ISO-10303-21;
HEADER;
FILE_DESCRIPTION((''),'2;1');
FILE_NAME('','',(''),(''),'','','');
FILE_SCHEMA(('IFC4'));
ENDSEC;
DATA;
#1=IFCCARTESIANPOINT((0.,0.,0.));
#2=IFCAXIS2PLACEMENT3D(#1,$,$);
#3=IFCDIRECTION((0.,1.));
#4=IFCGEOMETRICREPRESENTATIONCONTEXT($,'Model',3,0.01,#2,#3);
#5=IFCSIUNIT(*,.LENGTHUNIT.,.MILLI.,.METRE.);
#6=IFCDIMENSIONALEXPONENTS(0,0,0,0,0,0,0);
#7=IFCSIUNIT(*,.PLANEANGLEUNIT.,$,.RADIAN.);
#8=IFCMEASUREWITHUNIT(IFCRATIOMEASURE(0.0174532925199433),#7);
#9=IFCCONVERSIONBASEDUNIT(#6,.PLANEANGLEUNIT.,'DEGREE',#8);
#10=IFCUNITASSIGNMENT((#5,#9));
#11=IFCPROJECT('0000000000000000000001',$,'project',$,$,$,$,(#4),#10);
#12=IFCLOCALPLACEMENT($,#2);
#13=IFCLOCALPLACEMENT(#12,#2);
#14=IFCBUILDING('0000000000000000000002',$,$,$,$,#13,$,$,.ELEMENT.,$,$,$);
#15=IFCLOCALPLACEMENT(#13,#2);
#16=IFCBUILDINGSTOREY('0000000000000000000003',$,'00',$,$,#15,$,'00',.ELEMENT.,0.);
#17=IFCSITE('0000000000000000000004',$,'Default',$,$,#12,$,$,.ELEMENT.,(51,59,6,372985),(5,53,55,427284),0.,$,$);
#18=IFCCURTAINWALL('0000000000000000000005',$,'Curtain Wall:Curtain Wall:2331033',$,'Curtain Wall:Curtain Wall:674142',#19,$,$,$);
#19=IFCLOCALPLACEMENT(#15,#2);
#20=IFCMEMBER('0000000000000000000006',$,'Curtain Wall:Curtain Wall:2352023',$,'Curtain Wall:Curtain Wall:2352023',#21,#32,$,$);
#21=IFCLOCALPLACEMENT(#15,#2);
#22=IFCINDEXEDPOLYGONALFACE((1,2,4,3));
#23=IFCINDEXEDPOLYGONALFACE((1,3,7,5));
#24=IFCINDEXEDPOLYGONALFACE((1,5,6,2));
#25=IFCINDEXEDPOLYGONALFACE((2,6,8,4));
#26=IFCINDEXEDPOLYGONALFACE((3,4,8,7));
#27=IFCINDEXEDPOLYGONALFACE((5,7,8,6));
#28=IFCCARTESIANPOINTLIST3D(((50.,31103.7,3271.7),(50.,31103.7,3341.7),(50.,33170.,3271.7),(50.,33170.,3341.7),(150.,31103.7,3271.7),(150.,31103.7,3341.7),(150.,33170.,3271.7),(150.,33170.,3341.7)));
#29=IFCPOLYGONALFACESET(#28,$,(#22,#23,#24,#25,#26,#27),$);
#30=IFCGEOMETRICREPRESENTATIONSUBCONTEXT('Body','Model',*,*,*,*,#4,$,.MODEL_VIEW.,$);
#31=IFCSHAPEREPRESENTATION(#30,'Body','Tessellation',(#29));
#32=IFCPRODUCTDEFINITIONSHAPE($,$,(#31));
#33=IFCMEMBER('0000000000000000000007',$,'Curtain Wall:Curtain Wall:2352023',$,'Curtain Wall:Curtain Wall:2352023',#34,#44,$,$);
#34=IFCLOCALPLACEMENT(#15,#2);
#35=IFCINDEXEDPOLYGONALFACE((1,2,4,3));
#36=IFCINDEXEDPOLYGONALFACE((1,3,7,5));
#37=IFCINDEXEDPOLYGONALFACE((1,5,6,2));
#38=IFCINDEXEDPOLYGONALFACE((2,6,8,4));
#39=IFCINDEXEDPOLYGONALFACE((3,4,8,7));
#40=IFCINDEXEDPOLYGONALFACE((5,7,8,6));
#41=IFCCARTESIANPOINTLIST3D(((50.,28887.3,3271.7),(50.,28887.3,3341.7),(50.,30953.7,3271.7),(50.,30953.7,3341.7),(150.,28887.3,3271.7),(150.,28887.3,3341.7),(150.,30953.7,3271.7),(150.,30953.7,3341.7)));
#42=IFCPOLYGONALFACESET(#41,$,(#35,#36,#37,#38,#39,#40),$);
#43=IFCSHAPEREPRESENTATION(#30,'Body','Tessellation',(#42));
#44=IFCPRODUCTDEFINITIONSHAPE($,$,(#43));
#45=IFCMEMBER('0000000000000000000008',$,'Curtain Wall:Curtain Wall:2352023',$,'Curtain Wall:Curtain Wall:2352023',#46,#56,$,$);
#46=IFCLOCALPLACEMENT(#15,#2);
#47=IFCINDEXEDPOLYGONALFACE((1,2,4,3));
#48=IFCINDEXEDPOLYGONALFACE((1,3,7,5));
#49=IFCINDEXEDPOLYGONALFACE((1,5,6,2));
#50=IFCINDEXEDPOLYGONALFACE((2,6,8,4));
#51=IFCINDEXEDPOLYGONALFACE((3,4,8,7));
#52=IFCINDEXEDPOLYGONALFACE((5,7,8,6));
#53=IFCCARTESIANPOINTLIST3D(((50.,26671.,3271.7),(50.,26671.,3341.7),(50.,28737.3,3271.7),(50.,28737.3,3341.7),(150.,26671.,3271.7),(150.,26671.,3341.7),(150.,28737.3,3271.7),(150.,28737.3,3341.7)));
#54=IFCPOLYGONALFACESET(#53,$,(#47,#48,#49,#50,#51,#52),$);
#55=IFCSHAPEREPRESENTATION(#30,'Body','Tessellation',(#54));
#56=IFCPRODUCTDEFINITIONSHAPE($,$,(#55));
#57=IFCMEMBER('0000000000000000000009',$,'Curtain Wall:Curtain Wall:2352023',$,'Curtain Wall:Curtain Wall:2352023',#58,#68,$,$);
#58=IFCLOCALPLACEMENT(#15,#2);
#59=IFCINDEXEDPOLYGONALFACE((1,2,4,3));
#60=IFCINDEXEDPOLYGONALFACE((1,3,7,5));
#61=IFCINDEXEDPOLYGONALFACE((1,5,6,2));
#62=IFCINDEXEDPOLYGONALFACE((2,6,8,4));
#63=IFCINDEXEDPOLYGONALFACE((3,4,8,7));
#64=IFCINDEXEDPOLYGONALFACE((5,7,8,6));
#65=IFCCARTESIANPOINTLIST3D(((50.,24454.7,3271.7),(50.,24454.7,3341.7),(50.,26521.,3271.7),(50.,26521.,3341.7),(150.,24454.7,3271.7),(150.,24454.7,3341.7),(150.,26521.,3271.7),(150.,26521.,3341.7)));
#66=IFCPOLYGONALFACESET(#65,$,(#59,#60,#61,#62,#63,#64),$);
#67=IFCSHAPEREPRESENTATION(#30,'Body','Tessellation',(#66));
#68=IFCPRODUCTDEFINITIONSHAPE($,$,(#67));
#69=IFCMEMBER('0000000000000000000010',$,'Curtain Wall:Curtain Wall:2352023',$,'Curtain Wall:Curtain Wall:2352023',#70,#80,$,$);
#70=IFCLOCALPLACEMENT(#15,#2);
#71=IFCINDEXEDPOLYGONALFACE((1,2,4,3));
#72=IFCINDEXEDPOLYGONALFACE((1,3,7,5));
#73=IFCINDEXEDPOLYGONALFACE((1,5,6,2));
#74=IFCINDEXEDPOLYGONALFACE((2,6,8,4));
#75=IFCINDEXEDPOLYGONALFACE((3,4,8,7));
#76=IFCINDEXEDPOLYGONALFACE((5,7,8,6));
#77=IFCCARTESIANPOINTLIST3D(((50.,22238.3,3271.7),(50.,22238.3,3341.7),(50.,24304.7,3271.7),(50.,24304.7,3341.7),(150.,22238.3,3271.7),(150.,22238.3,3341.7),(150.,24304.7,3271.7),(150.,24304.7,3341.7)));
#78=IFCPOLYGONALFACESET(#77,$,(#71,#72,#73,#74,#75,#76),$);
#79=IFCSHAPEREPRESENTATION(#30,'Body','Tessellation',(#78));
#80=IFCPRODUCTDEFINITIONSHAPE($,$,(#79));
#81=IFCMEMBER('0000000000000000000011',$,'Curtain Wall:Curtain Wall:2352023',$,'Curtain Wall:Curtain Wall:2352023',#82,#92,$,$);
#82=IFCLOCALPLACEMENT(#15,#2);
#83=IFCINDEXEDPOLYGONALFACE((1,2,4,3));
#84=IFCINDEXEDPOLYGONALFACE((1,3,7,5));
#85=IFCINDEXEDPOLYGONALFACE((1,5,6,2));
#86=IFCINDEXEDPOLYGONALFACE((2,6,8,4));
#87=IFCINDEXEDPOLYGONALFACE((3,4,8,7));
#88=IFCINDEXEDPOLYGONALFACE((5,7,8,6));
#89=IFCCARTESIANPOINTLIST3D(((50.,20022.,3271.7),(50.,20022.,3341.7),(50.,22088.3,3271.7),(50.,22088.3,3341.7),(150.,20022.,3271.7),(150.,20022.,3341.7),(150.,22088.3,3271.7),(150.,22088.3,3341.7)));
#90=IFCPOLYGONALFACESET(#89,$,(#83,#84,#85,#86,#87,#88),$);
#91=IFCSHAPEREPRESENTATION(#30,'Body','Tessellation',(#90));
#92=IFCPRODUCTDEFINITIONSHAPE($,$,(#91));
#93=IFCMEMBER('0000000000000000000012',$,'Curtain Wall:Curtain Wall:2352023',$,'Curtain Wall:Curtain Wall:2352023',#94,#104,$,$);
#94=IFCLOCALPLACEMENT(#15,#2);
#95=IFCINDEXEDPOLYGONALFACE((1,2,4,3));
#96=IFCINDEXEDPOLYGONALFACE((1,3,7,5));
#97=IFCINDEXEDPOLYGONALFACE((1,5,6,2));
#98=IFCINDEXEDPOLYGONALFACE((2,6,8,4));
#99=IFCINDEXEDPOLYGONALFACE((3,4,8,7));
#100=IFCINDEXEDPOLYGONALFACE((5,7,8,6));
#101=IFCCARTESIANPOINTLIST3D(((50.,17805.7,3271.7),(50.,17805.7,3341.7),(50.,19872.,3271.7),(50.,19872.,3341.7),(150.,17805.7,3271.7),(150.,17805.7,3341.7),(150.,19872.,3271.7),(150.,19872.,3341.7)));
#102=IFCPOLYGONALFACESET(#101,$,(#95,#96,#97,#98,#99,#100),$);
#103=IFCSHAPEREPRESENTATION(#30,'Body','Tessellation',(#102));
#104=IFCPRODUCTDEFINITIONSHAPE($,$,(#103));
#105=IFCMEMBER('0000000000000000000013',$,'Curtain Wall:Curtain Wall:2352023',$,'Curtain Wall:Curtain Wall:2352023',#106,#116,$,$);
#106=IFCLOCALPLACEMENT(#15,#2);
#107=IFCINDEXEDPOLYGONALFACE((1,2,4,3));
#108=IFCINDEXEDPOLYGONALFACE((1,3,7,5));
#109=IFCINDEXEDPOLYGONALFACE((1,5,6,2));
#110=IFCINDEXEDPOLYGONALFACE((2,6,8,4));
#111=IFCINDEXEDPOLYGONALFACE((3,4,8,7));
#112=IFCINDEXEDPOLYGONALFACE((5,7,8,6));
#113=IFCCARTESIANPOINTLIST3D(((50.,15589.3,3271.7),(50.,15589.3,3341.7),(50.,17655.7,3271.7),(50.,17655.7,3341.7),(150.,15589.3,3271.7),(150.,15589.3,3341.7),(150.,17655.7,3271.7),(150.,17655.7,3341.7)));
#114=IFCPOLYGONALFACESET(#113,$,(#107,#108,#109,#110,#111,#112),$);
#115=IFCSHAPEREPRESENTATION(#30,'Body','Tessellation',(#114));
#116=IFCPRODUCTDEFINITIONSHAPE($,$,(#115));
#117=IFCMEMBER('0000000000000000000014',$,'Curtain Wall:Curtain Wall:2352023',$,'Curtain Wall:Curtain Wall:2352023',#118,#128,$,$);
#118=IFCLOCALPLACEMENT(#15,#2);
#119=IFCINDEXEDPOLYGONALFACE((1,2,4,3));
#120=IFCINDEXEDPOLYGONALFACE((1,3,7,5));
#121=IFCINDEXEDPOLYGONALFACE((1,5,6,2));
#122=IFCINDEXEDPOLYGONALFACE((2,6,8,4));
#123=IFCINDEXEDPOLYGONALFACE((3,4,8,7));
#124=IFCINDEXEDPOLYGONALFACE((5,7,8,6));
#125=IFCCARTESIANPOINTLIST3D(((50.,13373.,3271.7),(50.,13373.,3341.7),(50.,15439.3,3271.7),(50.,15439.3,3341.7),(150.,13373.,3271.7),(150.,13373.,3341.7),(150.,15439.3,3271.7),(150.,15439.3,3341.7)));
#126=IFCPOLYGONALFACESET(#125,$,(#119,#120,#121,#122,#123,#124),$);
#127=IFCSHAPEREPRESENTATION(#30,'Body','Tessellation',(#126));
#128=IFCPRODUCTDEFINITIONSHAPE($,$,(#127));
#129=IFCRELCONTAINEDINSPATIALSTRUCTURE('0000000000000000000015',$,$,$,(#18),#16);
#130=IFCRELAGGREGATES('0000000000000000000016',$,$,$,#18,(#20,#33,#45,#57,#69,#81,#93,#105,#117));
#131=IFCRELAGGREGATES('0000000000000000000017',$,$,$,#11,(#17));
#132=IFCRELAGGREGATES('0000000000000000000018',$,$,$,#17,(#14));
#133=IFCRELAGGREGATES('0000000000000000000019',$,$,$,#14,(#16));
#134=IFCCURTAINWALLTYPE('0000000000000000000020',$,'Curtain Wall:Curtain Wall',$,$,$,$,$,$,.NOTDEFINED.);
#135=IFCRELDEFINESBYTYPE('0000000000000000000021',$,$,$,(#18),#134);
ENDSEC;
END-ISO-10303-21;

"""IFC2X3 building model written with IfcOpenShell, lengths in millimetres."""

from ifc_helpers import new_model, entity, si_unit, converted_unit, direction, frame, frame_2d, origin, place, context, subcontext, project, spatial, rectangle, extrude, type_object, element, aggregate, save


model = new_model("IFC2X3")

# Units and contexts
model_context = context("Model", 3, precision=0.01, world=origin(), true_north=direction((0.0, 1.0)))
body_context = subcontext(model_context, "Body", "Model", "MODEL_VIEW")
ifc_project = project(units=[si_unit("LENGTHUNIT", "METRE", prefix="MILLI"), converted_unit("PLANEANGLEUNIT", "DEGREE", entity("IfcRatioMeasure", 0.0174532925199433), si_unit("PLANEANGLEUNIT", "RADIAN"), dimensions=[0, 0, 0, 0, 0, 0, 0])], contexts=[model_context])

# Site, building, storey
site_placement = place(None, origin())
site = spatial("IfcSite", under=ifc_project, at=site_placement, Name="Default", CompositionType="ELEMENT", RefLatitude=(51, 59, 6, 372985), RefLongitude=(5, 53, 55, 427284), RefElevation=0.0)
building_placement = place(site_placement, origin())
building = spatial("IfcBuilding", under=site, at=building_placement, CompositionType="ELEMENT")
storey_placement = place(building_placement, origin())
storey = spatial("IfcBuildingStorey", under=building, at=storey_placement, Name="00", LongName="00", CompositionType="ELEMENT", Elevation=0.0)

# Curtain wall, members
curtain_wall_type = type_object("IfcCurtainWallType", Name="Curtain Wall:Curtain Wall", PredefinedType="NOTDEFINED")
curtain_wall_placement = place(storey_placement, origin())
curtain_wall = element("IfcCurtainWall", 1, at=curtain_wall_placement, inside=storey, type_object=curtain_wall_type, Name="Curtain Wall:Curtain Wall:2331033", ObjectType="Curtain Wall:Curtain Wall:674142")
member_1_placement = place(curtain_wall_placement, origin())
member_1 = element("IfcMember", 2, at=member_1_placement, Name="Curtain Wall:Curtain Wall:2352023", ObjectType="Curtain Wall:Curtain Wall:2352023", context=body_context, shape_type="SweptSolid", body=[
    extrude(rectangle(XDim=70.0, YDim=100.0, at=frame_2d((0.0, 0.0), x_axis=(1.0, 0.0))), frame((100.0, 31103.7, 3306.7), z_axis=(0.0, 1.0, 0.0), x_axis=(0.0, 0.0, -1.0)), (0.0, 0.0, 1.0), 2066.3),
])
member_2_placement = place(curtain_wall_placement, origin())
member_2 = element("IfcMember", 3, at=member_2_placement, Name="Curtain Wall:Curtain Wall:2352023", ObjectType="Curtain Wall:Curtain Wall:2352023", context=body_context, shape_type="SweptSolid", body=[
    extrude(rectangle(XDim=70.0, YDim=100.0, at=frame_2d((0.0, 0.0), x_axis=(1.0, 0.0))), frame((100.0, 28887.3, 3306.7), z_axis=(0.0, 1.0, 0.0), x_axis=(0.0, 0.0, -1.0)), (0.0, 0.0, 1.0), 2066.3),
])
member_3_placement = place(curtain_wall_placement, origin())
member_3 = element("IfcMember", 4, at=member_3_placement, Name="Curtain Wall:Curtain Wall:2352023", ObjectType="Curtain Wall:Curtain Wall:2352023", context=body_context, shape_type="SweptSolid", body=[
    extrude(rectangle(XDim=70.0, YDim=100.0, at=frame_2d((0.0, 0.0), x_axis=(1.0, 0.0))), frame((100.0, 26671.0, 3306.7), z_axis=(0.0, 1.0, 0.0), x_axis=(0.0, 0.0, -1.0)), (0.0, 0.0, 1.0), 2066.3),
])
member_4_placement = place(curtain_wall_placement, origin())
member_4 = element("IfcMember", 5, at=member_4_placement, Name="Curtain Wall:Curtain Wall:2352023", ObjectType="Curtain Wall:Curtain Wall:2352023", context=body_context, shape_type="SweptSolid", body=[
    extrude(rectangle(XDim=70.0, YDim=100.0, at=frame_2d((0.0, 0.0), x_axis=(1.0, 0.0))), frame((100.0, 24454.7, 3306.7), z_axis=(0.0, 1.0, 0.0), x_axis=(0.0, 0.0, -1.0)), (0.0, 0.0, 1.0), 2066.3),
])
member_5_placement = place(curtain_wall_placement, origin())
member_5 = element("IfcMember", 6, at=member_5_placement, Name="Curtain Wall:Curtain Wall:2352023", ObjectType="Curtain Wall:Curtain Wall:2352023", context=body_context, shape_type="SweptSolid", body=[
    extrude(rectangle(XDim=70.0, YDim=100.0, at=frame_2d((0.0, 0.0), x_axis=(1.0, 0.0))), frame((100.0, 22238.3, 3306.7), z_axis=(0.0, 1.0, 0.0), x_axis=(0.0, 0.0, -1.0)), (0.0, 0.0, 1.0), 2066.3),
])
member_6_placement = place(curtain_wall_placement, origin())
member_6 = element("IfcMember", 7, at=member_6_placement, Name="Curtain Wall:Curtain Wall:2352023", ObjectType="Curtain Wall:Curtain Wall:2352023", context=body_context, shape_type="SweptSolid", body=[
    extrude(rectangle(XDim=70.0, YDim=100.0, at=frame_2d((0.0, 0.0), x_axis=(1.0, 0.0))), frame((100.0, 20022.0, 3306.7), z_axis=(0.0, 1.0, 0.0), x_axis=(0.0, 0.0, -1.0)), (0.0, 0.0, 1.0), 2066.3),
])
member_7_placement = place(curtain_wall_placement, origin())
member_7 = element("IfcMember", 8, at=member_7_placement, Name="Curtain Wall:Curtain Wall:2352023", ObjectType="Curtain Wall:Curtain Wall:2352023", context=body_context, shape_type="SweptSolid", body=[
    extrude(rectangle(XDim=70.0, YDim=100.0, at=frame_2d((0.0, 0.0), x_axis=(1.0, 0.0))), frame((100.0, 17805.7, 3306.7), z_axis=(0.0, 1.0, 0.0), x_axis=(0.0, 0.0, -1.0)), (0.0, 0.0, 1.0), 2066.3),
])
member_8_placement = place(curtain_wall_placement, origin())
member_8 = element("IfcMember", 9, at=member_8_placement, Name="Curtain Wall:Curtain Wall:2352023", ObjectType="Curtain Wall:Curtain Wall:2352023", context=body_context, shape_type="SweptSolid", body=[
    extrude(rectangle(XDim=70.0, YDim=100.0, at=frame_2d((0.0, 0.0), x_axis=(1.0, 0.0))), frame((100.0, 15589.3, 3306.7), z_axis=(0.0, 1.0, 0.0), x_axis=(0.0, 0.0, -1.0)), (0.0, 0.0, 1.0), 2066.3),
])
member_9_placement = place(curtain_wall_placement, origin())
member_9 = element("IfcMember", 10, at=member_9_placement, Name="Curtain Wall:Curtain Wall:2352023", ObjectType="Curtain Wall:Curtain Wall:2352023", context=body_context, shape_type="SweptSolid", body=[
    extrude(rectangle(XDim=70.0, YDim=100.0, at=frame_2d((0.0, 0.0), x_axis=(1.0, 0.0))), frame((100.0, 13373.0, 3306.7), z_axis=(0.0, 1.0, 0.0), x_axis=(0.0, 0.0, -1.0)), (0.0, 0.0, 1.0), 2066.3),
])
aggregate(curtain_wall, [member_1, member_2, member_3, member_4, member_5, member_6, member_7, member_8, member_9])

save(model, "model.ifc")
